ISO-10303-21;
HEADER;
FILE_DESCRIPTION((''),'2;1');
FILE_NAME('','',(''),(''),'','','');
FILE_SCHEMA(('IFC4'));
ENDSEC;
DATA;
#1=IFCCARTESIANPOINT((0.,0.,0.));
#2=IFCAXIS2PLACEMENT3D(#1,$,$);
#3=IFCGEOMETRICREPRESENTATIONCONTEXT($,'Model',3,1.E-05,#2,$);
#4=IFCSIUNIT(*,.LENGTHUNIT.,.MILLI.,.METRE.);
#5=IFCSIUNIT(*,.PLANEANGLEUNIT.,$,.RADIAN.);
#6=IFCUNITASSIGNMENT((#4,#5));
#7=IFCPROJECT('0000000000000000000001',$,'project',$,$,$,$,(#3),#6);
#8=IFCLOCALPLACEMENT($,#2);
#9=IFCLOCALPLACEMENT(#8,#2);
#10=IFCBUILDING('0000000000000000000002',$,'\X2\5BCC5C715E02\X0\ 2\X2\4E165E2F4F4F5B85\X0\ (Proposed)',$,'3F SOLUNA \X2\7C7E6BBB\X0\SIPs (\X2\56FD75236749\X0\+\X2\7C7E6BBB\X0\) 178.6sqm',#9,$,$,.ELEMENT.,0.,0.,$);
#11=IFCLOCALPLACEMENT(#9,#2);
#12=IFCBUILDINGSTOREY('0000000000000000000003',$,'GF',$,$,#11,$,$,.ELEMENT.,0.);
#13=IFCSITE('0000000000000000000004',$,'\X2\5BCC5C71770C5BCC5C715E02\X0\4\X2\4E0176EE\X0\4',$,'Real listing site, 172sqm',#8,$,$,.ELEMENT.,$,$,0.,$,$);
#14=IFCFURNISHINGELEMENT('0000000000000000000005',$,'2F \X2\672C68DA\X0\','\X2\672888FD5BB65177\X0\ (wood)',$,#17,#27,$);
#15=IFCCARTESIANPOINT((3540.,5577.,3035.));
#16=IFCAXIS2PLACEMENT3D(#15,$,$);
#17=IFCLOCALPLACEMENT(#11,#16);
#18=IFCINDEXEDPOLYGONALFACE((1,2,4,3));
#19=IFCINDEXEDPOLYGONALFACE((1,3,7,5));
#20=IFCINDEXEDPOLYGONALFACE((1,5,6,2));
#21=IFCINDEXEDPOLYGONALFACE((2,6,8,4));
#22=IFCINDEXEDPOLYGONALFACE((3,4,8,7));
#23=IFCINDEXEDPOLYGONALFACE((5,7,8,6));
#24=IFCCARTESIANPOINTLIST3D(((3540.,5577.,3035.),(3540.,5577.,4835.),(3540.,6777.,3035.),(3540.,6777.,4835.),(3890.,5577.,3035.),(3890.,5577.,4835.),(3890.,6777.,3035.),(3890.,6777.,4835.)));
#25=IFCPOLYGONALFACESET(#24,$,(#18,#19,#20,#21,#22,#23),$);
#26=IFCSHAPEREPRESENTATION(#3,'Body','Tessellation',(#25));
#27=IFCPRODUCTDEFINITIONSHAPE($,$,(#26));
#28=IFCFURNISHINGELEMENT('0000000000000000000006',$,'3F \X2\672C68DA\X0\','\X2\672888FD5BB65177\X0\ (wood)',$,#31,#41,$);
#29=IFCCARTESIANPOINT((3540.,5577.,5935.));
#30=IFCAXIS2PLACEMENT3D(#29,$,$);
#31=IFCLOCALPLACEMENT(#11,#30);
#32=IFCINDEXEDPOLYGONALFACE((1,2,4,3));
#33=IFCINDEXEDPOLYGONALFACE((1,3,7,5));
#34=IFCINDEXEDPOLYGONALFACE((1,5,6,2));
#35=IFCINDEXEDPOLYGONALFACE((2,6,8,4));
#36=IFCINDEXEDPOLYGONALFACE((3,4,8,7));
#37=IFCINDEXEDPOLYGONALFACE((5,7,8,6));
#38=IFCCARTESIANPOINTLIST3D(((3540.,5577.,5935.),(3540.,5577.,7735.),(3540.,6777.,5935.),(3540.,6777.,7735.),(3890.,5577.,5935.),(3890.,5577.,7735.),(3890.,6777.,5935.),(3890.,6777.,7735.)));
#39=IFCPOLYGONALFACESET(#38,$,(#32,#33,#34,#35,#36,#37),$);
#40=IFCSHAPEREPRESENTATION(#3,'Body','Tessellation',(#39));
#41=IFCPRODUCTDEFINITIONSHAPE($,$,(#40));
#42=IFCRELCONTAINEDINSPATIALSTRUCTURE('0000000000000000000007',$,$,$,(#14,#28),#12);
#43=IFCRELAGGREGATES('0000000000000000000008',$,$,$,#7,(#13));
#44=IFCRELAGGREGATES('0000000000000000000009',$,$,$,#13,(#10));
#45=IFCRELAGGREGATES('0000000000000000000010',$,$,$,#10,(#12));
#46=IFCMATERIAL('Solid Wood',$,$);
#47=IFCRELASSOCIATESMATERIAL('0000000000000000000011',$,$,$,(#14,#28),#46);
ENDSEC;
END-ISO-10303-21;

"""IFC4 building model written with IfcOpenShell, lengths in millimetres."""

from ifc_helpers import new_model, si_unit, frame, frame_2d, origin, place, context, project, spatial, rectangle, extrude, material, element, save


model = new_model("IFC4")

# Units and contexts
model_context = context("Model", 3, precision=1e-05, world=origin())
ifc_project = project(units=[si_unit("LENGTHUNIT", "METRE", prefix="MILLI"), si_unit("PLANEANGLEUNIT", "RADIAN")], contexts=[model_context])

# Site, building, storey
site_placement = place(None, origin())
site = spatial("IfcSite", under=ifc_project, at=site_placement, Name="富山県富山市4丁目4", ObjectType="Real listing site, 172sqm", CompositionType="ELEMENT", RefElevation=0.0)
building_placement = place(site_placement, origin())
building = spatial("IfcBuilding", under=site, at=building_placement, Name="富山市 2世帯住宅 (Proposed)", ObjectType="3F SOLUNA 籾殻SIPs (国産杉+籾殻) 178.6sqm", CompositionType="ELEMENT", ElevationOfRefHeight=0.0, ElevationOfTerrain=0.0)
storey_placement = place(building_placement, origin())
storey = spatial("IfcBuildingStorey", under=building, at=storey_placement, Name="GF", CompositionType="ELEMENT", Elevation=0.0)

# Shared definitions
ifc_material_1 = material(Name="Solid Wood")

# Furnishing elements
furnishing_1_placement = place(storey_placement, frame((3540.0, 5577.0, 3035.0)))
element("IfcFurnishingElement", 1, at=furnishing_1_placement, inside=storey, material=ifc_material_1, Name="2F 本棚", Description="木製家具 (wood)", context=model_context, shape_type="SweptSolid", body=[
    extrude(rectangle(XDim=350.0, YDim=1200.0, at=frame_2d((175.0, 600.0))), frame((3540.0, 5577.0, 3035.0)), (0.0, 0.0, 1.0), 1800.0),
])
furnishing_2_placement = place(storey_placement, frame((3540.0, 5577.0, 5935.0)))
element("IfcFurnishingElement", 2, at=furnishing_2_placement, inside=storey, material=ifc_material_1, Name="3F 本棚", Description="木製家具 (wood)", context=model_context, shape_type="SweptSolid", body=[
    extrude(rectangle(XDim=350.0, YDim=1200.0, at=frame_2d((175.0, 600.0))), frame((3540.0, 5577.0, 5935.0)), (0.0, 0.0, 1.0), 1800.0),
])

save(model, "model.ifc")
